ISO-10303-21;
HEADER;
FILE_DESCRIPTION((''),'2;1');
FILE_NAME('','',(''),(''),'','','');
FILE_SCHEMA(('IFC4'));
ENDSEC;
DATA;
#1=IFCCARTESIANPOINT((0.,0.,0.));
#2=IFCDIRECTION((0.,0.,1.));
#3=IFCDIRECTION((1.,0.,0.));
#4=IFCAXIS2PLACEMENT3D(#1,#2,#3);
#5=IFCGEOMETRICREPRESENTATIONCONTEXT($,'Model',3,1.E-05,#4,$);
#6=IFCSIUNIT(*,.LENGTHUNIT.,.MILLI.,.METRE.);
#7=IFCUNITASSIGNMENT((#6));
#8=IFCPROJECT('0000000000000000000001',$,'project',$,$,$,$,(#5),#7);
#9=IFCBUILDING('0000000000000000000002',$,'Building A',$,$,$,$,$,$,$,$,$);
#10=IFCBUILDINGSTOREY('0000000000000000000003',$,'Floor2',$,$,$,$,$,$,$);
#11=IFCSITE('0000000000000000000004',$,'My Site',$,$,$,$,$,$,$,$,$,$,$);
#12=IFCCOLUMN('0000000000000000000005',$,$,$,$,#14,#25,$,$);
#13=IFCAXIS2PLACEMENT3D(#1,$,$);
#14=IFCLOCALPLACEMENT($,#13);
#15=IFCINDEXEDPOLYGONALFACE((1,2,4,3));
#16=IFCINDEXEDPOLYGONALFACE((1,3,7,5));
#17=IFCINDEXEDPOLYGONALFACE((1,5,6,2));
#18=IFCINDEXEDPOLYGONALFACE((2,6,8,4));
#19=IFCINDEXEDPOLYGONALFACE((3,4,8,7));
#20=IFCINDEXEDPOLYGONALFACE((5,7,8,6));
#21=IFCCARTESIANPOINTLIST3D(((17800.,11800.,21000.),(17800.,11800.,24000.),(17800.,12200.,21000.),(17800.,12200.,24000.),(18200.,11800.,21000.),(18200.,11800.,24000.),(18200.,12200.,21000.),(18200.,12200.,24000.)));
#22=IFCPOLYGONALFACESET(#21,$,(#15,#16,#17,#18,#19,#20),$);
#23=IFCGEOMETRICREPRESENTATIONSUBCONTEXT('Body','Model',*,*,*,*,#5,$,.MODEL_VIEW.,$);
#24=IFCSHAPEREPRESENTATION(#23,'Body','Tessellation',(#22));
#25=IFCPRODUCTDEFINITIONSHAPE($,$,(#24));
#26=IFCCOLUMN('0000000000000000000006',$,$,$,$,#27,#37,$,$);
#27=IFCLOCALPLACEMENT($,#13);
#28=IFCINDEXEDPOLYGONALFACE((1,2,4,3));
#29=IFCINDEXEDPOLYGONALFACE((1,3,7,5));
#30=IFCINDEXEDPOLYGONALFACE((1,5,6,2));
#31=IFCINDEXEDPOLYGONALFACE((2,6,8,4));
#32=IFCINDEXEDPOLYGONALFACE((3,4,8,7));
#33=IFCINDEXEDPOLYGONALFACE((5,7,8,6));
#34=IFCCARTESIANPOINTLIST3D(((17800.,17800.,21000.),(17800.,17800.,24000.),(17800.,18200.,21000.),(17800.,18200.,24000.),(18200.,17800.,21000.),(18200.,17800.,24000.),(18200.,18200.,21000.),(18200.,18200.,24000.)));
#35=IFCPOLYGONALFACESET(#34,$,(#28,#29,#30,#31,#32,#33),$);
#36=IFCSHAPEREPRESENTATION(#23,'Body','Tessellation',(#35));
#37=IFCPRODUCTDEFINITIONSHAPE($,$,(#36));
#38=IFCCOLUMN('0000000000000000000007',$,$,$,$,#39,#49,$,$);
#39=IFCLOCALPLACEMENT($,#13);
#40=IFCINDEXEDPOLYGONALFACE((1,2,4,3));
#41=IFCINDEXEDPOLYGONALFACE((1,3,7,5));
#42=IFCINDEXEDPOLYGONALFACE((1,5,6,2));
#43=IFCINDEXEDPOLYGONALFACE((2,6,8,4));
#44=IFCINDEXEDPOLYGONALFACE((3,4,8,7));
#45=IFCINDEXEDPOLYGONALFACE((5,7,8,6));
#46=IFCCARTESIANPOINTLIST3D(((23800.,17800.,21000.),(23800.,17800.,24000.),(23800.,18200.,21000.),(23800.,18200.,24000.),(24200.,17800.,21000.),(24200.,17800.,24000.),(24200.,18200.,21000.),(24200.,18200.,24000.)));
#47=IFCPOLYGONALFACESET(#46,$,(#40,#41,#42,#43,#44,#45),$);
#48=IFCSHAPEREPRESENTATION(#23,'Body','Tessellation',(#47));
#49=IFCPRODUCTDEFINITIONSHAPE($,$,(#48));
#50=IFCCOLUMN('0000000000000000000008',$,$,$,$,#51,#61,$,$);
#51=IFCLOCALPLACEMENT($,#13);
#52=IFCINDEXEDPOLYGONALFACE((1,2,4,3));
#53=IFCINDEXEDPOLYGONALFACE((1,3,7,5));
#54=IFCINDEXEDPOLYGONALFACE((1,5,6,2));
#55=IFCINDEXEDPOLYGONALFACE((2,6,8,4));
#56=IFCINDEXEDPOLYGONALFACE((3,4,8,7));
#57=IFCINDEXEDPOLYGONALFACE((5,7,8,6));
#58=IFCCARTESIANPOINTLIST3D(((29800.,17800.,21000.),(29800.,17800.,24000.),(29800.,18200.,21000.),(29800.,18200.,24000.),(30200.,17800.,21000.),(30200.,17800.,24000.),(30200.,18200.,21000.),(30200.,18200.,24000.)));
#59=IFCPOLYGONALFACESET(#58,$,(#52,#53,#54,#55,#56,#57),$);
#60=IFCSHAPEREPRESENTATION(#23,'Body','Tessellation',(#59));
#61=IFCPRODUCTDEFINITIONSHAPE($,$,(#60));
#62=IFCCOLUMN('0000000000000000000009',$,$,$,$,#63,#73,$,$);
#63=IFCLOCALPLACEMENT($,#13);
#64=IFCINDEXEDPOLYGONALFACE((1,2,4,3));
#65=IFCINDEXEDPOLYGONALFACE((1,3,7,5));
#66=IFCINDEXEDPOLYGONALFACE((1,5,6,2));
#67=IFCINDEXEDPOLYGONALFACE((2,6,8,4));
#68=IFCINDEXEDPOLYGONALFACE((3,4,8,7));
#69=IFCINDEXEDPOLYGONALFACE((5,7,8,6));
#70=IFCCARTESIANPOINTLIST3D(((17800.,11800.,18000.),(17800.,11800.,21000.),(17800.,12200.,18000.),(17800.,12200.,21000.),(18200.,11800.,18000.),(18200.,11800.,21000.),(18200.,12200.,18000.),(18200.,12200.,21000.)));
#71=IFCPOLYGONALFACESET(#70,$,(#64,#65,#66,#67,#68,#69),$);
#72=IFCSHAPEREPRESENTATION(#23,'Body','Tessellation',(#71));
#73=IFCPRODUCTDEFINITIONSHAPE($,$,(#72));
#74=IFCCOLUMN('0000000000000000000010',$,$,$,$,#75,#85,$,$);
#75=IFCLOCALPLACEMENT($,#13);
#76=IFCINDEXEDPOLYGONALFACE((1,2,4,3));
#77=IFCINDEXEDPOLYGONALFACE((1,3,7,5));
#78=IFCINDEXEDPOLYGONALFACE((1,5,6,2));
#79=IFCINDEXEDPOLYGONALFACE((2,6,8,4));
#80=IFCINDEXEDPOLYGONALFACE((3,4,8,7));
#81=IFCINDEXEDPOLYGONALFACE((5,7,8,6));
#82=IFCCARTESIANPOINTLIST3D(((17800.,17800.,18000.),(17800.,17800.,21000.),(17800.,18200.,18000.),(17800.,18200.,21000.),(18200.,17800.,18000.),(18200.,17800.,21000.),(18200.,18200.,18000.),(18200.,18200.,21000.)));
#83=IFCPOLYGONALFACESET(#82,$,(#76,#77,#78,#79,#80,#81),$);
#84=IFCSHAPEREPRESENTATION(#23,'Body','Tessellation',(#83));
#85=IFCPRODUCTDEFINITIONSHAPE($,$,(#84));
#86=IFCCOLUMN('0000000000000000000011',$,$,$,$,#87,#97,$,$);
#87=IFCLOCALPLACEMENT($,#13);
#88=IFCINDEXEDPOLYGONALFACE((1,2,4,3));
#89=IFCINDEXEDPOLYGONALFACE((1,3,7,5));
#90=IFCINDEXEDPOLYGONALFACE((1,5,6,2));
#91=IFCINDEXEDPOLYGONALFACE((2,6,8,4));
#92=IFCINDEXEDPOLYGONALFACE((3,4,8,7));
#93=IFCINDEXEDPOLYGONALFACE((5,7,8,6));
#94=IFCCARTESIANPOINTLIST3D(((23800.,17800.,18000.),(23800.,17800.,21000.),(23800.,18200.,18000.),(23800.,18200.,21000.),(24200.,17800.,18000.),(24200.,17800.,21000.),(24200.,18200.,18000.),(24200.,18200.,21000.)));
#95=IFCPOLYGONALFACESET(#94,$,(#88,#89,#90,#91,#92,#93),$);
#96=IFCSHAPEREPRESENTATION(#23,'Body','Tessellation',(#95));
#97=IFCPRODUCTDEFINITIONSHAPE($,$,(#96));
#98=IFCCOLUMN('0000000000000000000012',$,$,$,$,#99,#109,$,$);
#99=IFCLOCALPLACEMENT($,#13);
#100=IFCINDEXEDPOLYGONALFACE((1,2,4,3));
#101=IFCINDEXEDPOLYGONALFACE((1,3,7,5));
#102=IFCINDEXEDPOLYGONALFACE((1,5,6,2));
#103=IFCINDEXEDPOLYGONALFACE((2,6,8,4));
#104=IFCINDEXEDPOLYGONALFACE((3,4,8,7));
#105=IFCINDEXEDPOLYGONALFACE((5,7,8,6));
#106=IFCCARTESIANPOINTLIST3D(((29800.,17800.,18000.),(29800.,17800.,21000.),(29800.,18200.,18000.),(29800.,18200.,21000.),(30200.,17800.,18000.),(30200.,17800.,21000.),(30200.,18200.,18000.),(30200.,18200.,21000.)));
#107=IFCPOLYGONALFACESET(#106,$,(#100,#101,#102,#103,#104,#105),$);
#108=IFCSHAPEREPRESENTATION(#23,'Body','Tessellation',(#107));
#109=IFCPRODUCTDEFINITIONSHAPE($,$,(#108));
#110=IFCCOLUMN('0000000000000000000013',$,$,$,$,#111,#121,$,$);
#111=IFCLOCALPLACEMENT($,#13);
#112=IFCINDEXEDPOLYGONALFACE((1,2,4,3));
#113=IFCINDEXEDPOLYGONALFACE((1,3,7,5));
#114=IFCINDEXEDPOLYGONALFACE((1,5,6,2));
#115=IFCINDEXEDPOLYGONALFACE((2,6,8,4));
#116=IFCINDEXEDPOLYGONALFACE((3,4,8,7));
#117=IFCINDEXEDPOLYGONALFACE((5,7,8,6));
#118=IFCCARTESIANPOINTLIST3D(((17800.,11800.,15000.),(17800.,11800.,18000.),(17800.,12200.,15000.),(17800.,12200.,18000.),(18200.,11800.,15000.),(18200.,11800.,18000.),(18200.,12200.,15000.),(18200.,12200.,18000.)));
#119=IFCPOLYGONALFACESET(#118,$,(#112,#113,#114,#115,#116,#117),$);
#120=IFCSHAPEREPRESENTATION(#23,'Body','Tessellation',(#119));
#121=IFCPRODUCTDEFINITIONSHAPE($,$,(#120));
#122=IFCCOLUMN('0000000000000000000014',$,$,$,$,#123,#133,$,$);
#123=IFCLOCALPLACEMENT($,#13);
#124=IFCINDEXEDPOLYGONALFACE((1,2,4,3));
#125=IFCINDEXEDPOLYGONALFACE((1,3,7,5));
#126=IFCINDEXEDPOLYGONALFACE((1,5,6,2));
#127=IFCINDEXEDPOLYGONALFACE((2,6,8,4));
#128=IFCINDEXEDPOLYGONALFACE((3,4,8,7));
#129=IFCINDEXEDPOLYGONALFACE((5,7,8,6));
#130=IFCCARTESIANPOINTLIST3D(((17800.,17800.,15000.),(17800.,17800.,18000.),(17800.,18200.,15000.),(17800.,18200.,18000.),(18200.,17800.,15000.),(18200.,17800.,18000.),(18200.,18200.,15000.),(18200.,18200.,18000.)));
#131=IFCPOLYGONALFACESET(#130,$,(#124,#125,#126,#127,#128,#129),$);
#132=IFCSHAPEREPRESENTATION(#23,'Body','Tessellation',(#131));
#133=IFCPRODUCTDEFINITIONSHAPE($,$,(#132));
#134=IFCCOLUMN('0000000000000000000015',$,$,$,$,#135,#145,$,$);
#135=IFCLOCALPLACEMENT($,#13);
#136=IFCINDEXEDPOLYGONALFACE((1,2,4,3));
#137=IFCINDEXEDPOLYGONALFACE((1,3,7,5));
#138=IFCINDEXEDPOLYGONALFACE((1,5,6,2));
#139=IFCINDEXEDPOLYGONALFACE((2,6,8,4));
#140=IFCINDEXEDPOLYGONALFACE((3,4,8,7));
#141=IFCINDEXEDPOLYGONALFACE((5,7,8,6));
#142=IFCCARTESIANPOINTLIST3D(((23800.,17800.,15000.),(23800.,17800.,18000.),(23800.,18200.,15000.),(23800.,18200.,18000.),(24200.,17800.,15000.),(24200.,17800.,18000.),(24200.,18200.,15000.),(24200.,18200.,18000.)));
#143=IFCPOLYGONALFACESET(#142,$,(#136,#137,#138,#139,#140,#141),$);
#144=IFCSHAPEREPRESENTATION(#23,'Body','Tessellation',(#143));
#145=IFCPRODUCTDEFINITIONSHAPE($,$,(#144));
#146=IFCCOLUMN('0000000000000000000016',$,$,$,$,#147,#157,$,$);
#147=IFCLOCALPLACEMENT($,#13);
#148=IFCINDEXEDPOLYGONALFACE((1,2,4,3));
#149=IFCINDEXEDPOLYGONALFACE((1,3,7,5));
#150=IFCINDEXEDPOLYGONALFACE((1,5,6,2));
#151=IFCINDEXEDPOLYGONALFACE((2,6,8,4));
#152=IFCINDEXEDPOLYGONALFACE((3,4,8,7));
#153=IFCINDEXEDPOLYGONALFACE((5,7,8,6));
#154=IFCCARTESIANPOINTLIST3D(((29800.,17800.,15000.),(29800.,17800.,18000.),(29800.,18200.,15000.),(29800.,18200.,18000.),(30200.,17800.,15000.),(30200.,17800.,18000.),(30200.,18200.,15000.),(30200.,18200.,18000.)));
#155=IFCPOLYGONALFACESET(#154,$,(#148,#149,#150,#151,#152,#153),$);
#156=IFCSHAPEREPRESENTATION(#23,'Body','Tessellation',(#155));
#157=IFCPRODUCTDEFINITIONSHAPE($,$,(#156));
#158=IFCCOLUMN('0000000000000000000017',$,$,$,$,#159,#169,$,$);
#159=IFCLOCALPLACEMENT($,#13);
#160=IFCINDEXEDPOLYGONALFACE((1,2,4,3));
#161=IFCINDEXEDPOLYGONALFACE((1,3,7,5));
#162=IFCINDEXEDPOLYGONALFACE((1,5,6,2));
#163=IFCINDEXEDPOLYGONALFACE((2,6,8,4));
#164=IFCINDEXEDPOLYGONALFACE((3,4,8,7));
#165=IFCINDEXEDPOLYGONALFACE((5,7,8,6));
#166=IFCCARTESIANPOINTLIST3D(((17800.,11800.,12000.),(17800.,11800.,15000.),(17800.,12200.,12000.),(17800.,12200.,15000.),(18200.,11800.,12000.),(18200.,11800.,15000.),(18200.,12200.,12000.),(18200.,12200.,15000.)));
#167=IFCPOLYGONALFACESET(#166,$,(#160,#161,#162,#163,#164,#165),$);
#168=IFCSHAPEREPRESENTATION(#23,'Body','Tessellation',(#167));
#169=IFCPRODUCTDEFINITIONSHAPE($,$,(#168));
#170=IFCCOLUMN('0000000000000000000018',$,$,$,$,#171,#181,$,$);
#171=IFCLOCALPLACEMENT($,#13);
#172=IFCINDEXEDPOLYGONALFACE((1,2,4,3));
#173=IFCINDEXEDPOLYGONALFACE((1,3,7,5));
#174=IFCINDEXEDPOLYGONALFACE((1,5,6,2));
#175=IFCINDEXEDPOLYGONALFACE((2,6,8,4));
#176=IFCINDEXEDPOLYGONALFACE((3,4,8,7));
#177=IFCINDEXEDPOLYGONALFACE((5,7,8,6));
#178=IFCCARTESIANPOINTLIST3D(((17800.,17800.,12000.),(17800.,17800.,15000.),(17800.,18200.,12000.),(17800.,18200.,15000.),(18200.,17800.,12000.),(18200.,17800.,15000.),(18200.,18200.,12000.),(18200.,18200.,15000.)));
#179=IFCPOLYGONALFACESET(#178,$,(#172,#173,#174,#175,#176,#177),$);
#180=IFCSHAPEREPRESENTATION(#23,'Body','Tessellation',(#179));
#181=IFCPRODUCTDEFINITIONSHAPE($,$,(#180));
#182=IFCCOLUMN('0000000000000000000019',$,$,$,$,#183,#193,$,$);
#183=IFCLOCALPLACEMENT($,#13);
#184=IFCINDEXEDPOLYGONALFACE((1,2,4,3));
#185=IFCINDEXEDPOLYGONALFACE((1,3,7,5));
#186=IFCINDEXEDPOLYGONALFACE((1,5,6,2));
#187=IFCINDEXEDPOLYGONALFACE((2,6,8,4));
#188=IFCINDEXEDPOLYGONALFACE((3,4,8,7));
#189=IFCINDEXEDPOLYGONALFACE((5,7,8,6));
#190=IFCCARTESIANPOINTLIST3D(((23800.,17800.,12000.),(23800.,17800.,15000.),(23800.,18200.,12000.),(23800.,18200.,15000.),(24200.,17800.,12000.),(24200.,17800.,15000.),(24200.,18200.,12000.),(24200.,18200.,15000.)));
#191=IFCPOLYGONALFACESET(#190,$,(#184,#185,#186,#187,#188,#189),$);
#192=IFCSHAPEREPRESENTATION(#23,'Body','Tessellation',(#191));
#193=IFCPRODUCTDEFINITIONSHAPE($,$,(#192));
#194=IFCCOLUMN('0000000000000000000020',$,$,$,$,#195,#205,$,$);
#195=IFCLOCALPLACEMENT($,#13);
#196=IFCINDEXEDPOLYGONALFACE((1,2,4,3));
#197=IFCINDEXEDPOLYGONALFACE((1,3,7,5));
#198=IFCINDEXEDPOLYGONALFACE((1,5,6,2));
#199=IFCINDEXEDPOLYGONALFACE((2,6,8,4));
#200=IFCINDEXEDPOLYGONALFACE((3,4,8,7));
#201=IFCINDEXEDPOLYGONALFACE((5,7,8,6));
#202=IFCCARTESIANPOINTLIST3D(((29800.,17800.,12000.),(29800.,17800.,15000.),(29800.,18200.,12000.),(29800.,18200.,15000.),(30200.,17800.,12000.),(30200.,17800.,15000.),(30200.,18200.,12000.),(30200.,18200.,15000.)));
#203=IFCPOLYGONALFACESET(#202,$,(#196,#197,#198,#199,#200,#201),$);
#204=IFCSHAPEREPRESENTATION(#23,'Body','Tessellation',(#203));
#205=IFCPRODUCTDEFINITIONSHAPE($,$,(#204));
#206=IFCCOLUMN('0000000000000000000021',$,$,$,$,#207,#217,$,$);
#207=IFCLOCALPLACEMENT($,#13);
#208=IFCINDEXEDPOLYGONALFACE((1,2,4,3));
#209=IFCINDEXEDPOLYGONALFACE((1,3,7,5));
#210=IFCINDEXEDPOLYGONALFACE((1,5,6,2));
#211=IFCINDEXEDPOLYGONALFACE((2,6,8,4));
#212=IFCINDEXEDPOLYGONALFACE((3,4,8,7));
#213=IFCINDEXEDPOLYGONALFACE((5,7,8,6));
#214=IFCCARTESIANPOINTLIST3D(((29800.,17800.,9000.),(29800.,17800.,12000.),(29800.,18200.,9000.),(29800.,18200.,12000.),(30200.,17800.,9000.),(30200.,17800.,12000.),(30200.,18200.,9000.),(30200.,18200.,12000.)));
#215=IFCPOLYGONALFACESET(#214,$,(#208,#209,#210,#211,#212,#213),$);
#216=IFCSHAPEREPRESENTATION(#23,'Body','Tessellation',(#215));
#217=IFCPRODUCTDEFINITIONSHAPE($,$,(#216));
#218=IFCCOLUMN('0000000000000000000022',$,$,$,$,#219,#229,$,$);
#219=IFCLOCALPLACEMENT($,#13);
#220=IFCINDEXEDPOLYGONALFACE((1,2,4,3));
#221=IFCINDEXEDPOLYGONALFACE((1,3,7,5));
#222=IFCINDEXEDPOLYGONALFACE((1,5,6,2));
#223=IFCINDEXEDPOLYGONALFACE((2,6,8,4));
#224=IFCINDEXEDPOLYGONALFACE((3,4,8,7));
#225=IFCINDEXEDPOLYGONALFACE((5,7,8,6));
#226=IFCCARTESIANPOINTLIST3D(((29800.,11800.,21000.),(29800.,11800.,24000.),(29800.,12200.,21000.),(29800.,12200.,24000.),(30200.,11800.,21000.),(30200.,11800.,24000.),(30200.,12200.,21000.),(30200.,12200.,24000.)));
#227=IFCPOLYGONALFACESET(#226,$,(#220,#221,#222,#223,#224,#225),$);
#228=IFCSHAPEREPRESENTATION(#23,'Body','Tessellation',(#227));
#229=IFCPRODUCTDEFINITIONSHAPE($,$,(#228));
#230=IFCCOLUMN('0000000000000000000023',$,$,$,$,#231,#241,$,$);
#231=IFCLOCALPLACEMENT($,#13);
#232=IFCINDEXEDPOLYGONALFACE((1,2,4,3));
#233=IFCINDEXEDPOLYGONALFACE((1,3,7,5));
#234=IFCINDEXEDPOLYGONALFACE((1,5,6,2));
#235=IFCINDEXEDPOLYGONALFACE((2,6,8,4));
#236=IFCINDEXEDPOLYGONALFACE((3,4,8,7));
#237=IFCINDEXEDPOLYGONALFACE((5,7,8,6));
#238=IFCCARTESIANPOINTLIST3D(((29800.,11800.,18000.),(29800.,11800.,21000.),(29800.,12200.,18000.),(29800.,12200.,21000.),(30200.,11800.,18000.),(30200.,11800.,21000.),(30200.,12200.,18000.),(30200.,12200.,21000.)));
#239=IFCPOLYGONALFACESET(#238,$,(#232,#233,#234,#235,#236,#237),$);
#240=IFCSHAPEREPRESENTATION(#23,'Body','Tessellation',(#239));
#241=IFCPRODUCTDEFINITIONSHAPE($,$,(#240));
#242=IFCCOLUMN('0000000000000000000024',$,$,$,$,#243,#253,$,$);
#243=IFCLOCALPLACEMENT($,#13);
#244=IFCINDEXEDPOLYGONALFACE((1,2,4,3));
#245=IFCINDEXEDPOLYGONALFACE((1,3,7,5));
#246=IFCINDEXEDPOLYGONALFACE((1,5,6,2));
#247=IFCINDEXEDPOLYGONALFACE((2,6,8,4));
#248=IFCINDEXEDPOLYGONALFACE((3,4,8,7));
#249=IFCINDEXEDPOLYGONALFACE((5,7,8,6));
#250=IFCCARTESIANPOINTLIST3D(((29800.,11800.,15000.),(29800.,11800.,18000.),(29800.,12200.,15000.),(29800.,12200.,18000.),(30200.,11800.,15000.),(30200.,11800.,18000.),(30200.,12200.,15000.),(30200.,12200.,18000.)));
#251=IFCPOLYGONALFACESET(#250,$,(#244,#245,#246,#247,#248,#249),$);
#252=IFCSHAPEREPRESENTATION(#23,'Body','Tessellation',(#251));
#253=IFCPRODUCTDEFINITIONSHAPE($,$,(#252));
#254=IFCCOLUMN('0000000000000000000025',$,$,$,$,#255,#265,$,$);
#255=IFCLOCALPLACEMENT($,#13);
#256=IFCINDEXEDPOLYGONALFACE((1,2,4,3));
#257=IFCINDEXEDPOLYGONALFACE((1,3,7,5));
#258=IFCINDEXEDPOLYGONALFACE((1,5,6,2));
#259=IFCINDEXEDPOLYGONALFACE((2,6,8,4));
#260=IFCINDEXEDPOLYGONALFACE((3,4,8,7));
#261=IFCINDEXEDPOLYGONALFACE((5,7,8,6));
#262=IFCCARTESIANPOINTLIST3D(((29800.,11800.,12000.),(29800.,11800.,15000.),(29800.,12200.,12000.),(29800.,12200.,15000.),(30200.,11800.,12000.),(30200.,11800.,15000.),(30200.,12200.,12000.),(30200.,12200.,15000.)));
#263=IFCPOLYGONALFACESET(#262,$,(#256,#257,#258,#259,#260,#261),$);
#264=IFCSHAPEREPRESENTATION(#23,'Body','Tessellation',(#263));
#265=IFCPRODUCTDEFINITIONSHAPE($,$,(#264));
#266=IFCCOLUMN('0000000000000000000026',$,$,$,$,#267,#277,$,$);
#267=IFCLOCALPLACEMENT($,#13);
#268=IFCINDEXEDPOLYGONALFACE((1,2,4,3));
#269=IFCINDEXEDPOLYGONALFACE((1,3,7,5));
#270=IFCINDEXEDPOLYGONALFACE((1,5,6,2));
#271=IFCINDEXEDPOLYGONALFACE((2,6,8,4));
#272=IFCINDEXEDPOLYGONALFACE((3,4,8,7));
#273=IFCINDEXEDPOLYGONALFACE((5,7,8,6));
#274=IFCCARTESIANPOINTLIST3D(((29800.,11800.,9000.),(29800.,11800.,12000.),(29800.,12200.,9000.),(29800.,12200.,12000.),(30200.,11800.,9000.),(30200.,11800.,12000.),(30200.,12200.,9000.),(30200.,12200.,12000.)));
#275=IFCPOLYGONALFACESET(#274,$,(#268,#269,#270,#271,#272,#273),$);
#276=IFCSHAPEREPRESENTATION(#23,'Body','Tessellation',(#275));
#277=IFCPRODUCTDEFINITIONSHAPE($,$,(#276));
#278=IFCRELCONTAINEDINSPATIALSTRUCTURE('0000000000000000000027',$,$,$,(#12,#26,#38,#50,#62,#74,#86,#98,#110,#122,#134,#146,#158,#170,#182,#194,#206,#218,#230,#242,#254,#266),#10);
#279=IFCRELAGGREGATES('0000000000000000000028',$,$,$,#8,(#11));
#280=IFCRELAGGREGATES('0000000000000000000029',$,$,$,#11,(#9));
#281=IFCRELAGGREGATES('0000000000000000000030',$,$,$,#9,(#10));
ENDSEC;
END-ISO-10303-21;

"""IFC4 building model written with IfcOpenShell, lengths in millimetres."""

from ifc_helpers import new_model, si_unit, frame, origin_with_axes, place, context, subcontext, project, spatial, line, indexed_curve, outline, extrude, element, save


model = new_model("IFC4")

# Units and contexts
model_context = context("Model", 3, precision=1e-05, world=origin_with_axes())
body_context = subcontext(model_context, "Body", "Model", "MODEL_VIEW")
ifc_project = project(units=[si_unit("LENGTHUNIT", "METRE", prefix="MILLI")], contexts=[model_context])

# Site, building, storey
site = spatial("IfcSite", under=ifc_project, Name="My Site")
building = spatial("IfcBuilding", under=site, Name="Building A")
storey = spatial("IfcBuildingStorey", under=building, Name="Floor2")

# Columns
for number, where, z_axis, x_axis in (
    (1, (18000.0, 12000.0, 21000.0), (0.0, 0.0, 1.0), (1.0, 0.0, 0.0)),
    (2, (18000.0, 18000.0, 21000.0), (0.0, 0.0, 1.0), (1.0, 0.0, 0.0)),
    (3, (24000.0, 18000.0, 21000.0), (0.0, 0.0, 1.0), (1.0, 0.0, 0.0)),
    (4, (30000.0, 18000.0, 21000.0), (0.0, 0.0, 1.0), (1.0, 0.0, 0.0)),
    (5, (18000.0, 12000.0, 18000.0), (0.0, 0.0, 1.0), (1.0, 0.0, 0.0)),
    (6, (18000.0, 18000.0, 18000.0), (0.0, 0.0, 1.0), (1.0, 0.0, 0.0)),
    (7, (24000.0, 18000.0, 18000.0), (0.0, 0.0, 1.0), (1.0, 0.0, 0.0)),
    (8, (30000.0, 18000.0, 18000.0), (0.0, 0.0, 1.0), (1.0, 0.0, 0.0)),
    (9, (18000.0, 12000.0, 15000.0), (0.0, 0.0, 1.0), (1.0, 0.0, 0.0)),
    (10, (18000.0, 18000.0, 15000.0), (0.0, 0.0, 1.0), (1.0, 0.0, 0.0)),
    (11, (24000.0, 18000.0, 15000.0), (0.0, 0.0, 1.0), (1.0, 0.0, 0.0)),
    (12, (30000.0, 18000.0, 15000.0), (0.0, 0.0, 1.0), (1.0, 0.0, 0.0)),
    (13, (18000.0, 12000.0, 12000.0), (0.0, 0.0, 1.0), (1.0, 0.0, 0.0)),
    (14, (18000.0, 18000.0, 12000.0), (0.0, 0.0, 1.0), (1.0, 0.0, 0.0)),
    (15, (24000.0, 18000.0, 12000.0), (0.0, 0.0, 1.0), (1.0, 0.0, 0.0)),
    (16, (30000.0, 18000.0, 12000.0), (0.0, 0.0, 1.0), (1.0, 0.0, 0.0)),
    (17, (30000.0, 18000.0, 9000.0), (0.0, 0.0, 1.0), (1.0, 0.0, 0.0)),
    (18, (30000.0, 12000.0, 21000.0), (0.0, 0.0, 1.0), (1.0, 0.0, 0.0)),
    (19, (30000.0, 12000.0, 18000.0), (0.0, 0.0, 1.0), (1.0, 0.0, 0.0)),
    (20, (30000.0, 12000.0, 15000.0), (0.0, 0.0, 1.0), (1.0, 0.0, 0.0)),
    (21, (30000.0, 12000.0, 12000.0), (0.0, 0.0, 1.0), (1.0, 0.0, 0.0)),
    (22, (30000.0, 12000.0, 9000.0), (0.0, 0.0, 1.0), (1.0, 0.0, 0.0)),
):
    element("IfcColumn", number, at=place(None, frame(where, z_axis=z_axis, x_axis=x_axis)), inside=storey, context=body_context, shape_type="SweptSolid", body=[
        extrude(outline(indexed_curve([(-200.0, -200.0), (200.0, -200.0), (200.0, 200.0), (-200.0, 200.0)], segments=[line(1, 2, 3, 4, 1)])), origin_with_axes(), (0.0, 0.0, 1.0), 3000.0),
    ])

save(model, "model.ifc")
